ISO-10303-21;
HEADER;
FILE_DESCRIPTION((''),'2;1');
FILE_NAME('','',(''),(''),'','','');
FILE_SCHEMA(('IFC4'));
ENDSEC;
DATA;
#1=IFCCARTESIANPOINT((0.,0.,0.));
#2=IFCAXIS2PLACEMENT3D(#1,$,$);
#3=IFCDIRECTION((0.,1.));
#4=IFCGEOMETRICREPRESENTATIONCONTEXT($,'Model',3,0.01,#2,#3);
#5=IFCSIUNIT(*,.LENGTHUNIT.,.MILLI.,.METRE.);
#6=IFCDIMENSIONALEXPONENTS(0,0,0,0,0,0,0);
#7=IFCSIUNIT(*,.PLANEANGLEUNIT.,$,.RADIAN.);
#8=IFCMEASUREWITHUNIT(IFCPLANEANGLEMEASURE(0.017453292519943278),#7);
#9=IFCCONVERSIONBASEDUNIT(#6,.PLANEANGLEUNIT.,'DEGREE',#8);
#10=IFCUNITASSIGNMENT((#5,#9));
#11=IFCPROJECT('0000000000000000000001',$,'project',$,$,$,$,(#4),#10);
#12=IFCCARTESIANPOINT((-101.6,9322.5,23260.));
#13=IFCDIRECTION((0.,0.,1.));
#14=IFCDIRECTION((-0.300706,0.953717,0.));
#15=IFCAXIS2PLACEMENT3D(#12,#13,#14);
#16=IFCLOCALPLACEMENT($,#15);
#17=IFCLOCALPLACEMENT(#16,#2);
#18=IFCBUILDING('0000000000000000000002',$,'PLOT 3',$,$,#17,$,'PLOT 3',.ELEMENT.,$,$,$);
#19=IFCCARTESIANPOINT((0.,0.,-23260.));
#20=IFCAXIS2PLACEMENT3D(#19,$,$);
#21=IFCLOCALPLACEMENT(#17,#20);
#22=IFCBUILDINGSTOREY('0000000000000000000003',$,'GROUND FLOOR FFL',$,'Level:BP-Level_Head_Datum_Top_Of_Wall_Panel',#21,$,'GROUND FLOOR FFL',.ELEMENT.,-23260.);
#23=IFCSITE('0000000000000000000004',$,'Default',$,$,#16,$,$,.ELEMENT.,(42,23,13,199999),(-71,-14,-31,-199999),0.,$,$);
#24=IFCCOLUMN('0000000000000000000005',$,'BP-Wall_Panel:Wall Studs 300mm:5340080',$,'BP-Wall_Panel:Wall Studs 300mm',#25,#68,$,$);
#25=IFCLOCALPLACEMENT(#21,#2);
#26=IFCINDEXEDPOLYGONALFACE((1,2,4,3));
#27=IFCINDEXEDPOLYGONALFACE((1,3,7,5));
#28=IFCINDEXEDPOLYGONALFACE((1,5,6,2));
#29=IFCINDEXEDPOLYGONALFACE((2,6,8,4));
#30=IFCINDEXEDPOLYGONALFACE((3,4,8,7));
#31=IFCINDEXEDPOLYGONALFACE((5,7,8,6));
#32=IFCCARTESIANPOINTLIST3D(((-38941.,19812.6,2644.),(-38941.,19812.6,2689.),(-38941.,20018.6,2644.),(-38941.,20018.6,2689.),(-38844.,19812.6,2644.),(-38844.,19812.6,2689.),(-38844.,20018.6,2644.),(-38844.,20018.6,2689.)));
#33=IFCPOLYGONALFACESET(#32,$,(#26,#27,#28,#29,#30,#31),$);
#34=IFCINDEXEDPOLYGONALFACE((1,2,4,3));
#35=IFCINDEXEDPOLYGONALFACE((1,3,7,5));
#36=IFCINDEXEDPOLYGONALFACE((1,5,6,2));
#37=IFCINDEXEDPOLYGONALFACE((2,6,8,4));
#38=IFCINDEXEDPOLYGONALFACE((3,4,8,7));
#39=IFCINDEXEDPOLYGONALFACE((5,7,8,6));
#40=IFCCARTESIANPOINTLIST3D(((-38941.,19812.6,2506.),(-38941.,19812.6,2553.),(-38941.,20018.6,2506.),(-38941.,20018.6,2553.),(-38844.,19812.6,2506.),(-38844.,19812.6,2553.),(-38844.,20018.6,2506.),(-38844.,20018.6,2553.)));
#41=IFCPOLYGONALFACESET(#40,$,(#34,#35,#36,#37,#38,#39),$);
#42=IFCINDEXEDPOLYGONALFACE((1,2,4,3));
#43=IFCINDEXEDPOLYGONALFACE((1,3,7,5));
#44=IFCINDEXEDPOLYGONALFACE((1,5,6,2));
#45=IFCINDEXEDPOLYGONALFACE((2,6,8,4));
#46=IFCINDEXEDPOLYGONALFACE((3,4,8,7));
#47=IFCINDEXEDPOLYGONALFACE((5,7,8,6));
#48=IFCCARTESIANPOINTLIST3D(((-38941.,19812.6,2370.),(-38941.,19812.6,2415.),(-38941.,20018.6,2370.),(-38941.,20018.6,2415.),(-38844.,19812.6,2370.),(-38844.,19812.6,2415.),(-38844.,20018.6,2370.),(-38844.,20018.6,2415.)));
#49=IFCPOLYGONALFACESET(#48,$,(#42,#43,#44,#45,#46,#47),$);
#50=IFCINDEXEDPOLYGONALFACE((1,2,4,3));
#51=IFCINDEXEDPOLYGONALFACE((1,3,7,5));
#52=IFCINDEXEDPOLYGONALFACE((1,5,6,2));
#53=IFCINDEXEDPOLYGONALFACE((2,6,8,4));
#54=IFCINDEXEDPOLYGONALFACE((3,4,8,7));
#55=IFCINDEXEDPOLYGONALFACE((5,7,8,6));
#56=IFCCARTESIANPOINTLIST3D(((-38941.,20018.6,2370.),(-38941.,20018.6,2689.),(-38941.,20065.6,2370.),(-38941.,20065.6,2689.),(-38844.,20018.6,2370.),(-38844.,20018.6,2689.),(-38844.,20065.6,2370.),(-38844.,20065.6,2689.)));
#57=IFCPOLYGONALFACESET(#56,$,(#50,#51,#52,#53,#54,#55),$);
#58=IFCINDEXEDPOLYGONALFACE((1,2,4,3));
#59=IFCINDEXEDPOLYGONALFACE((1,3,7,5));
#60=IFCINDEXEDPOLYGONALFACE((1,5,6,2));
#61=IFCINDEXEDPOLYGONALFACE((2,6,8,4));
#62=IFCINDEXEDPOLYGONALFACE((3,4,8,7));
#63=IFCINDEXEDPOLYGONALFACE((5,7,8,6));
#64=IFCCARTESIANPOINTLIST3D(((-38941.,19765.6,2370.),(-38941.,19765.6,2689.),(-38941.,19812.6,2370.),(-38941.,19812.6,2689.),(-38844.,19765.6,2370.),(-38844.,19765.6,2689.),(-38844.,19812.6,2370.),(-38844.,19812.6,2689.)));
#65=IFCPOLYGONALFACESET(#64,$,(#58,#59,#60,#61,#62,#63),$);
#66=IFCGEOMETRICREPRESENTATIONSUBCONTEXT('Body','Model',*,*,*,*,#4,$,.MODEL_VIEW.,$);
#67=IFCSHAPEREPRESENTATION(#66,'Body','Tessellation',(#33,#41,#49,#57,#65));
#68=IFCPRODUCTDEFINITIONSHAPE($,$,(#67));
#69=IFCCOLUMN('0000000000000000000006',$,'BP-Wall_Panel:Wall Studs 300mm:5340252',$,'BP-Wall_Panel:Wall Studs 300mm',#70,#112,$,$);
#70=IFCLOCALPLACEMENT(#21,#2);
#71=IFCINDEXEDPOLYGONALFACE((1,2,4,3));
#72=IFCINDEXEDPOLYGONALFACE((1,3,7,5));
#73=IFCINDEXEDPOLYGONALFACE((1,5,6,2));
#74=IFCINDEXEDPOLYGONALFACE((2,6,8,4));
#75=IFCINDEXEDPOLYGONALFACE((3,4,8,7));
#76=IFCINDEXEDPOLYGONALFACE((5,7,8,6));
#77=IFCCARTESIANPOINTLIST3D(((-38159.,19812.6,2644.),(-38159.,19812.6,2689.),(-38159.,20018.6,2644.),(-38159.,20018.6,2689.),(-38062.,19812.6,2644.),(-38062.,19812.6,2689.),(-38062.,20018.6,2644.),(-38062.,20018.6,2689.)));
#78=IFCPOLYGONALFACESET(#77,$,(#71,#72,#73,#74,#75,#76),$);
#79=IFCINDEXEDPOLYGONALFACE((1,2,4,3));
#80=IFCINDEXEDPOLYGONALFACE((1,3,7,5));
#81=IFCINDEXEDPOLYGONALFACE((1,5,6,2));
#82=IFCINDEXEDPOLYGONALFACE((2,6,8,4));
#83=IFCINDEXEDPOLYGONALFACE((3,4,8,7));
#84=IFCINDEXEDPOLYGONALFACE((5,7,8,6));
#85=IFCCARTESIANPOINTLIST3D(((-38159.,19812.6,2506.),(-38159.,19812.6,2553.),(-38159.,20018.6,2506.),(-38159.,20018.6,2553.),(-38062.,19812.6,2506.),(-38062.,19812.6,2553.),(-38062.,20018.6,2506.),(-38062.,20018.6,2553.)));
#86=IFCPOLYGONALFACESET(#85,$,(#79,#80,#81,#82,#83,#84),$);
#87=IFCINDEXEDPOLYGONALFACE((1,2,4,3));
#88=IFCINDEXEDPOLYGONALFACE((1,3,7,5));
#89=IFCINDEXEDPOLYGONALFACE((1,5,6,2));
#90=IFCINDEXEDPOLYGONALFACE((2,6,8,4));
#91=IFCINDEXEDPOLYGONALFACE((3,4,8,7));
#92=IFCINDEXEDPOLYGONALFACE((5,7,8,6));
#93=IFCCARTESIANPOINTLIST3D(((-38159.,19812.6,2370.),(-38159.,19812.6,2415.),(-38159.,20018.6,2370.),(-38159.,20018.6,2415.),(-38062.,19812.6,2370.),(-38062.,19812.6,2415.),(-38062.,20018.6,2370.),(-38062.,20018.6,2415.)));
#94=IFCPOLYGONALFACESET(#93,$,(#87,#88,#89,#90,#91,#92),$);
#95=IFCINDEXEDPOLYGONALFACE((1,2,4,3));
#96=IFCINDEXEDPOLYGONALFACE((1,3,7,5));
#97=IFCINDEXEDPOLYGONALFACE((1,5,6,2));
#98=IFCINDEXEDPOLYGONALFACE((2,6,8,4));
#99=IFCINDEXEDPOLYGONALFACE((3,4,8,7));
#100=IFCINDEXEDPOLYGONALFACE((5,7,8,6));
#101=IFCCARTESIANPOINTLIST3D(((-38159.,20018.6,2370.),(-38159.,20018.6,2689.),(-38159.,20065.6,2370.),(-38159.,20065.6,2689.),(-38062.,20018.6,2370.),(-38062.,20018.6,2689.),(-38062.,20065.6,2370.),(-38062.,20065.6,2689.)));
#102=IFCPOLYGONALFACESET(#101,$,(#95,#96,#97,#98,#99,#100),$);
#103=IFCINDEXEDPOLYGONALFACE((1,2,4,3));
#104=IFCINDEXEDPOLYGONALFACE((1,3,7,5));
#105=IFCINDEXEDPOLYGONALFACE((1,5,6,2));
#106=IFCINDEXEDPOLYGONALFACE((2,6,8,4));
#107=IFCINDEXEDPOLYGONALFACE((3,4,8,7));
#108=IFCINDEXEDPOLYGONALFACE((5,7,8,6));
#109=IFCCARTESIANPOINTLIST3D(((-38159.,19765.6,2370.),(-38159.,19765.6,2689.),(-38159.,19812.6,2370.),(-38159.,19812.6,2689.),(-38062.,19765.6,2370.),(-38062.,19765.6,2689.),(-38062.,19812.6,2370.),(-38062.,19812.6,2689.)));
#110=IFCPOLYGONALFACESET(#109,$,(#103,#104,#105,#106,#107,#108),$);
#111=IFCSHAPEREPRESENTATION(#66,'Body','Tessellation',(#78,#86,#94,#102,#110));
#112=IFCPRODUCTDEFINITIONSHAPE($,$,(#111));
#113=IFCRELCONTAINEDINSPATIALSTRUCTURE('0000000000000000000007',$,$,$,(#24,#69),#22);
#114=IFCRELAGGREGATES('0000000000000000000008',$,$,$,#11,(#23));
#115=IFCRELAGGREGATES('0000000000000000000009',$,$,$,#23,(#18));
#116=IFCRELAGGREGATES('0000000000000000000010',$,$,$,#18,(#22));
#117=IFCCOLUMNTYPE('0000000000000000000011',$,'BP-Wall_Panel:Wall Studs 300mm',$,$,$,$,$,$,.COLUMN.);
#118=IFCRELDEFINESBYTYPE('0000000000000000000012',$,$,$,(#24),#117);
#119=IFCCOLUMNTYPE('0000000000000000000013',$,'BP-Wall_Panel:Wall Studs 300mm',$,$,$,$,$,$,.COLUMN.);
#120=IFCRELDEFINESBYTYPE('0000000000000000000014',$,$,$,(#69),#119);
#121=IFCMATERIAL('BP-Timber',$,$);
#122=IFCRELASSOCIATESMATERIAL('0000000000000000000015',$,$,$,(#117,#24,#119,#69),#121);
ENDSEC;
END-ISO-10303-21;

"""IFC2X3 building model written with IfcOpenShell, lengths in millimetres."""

from ifc_helpers import new_model, entity, si_unit, converted_unit, direction, frame, frame_2d, origin, place, context, subcontext, project, spatial, rectangle, extrude, source, transform, mapped, material, type_object, type_shapes, element, save


model = new_model("IFC2X3")

# Units and contexts
model_context = context("Model", 3, precision=0.01, world=origin(), true_north=direction((0.0, 1.0)))
body_context = subcontext(model_context, "Body", "Model", "MODEL_VIEW")
ifc_project = project(units=[si_unit("LENGTHUNIT", "METRE", prefix="MILLI"), converted_unit("PLANEANGLEUNIT", "DEGREE", entity("IfcPlaneAngleMeasure", 0.017453292519943278), si_unit("PLANEANGLEUNIT", "RADIAN"), dimensions=[0, 0, 0, 0, 0, 0, 0])], contexts=[model_context])

# Site, building, storey
site_placement = place(None, frame((-101.6, 9322.5, 23260.0), z_axis=(0.0, 0.0, 1.0), x_axis=(-0.300706, 0.953717, 0.0)))
site = spatial("IfcSite", under=ifc_project, at=site_placement, Name="Default", CompositionType="ELEMENT", RefLatitude=(42, 23, 13, 199999), RefLongitude=(-71, -14, -31, -199999), RefElevation=0.0)
building_placement = place(site_placement, origin())
building = spatial("IfcBuilding", under=site, at=building_placement, Name="PLOT 3", LongName="PLOT 3", CompositionType="ELEMENT")
storey_placement = place(building_placement, frame((0.0, 0.0, -23260.0)))
storey = spatial("IfcBuildingStorey", under=building, at=storey_placement, Name="GROUND FLOOR FFL", ObjectType="Level:BP-Level_Head_Datum_Top_Of_Wall_Panel", LongName="GROUND FLOOR FFL", CompositionType="ELEMENT", Elevation=-23260.0)

# Columns
ifc_material_1 = material(Name="BP-Timber")
column_type_1 = type_object("IfcColumnType", Name="BP-Wall_Panel:Wall Studs 300mm", PredefinedType="COLUMN", material=ifc_material_1)
shared_shape_1 = source(origin(), body_context, "Body", "SweptSolid", [
    extrude(rectangle(XDim=97.0, YDim=206.0, at=frame_2d((0.0, 0.0), x_axis=(1.0, 0.0))), frame((-38892.5, 19915.6, -20616.0), z_axis=(0.0, 0.0, 1.0), x_axis=(-1.0, 0.0, 0.0)), (0.0, 0.0, 1.0), 45.0),
    extrude(rectangle(XDim=97.0, YDim=206.0, at=frame_2d((0.0, 0.0), x_axis=(1.0, 0.0))), frame((-38892.5, 19915.6, -20754.0), z_axis=(0.0, 0.0, 1.0), x_axis=(-1.0, 0.0, 0.0)), (0.0, 0.0, 1.0), 47.0),
    extrude(rectangle(XDim=97.0, YDim=206.0, at=frame_2d((0.0, 0.0), x_axis=(1.0, 0.0))), frame((-38892.5, 19915.6, -20890.0), z_axis=(0.0, 0.0, 1.0), x_axis=(-1.0, 0.0, 0.0)), (0.0, 0.0, 1.0), 45.0),
    extrude(rectangle(XDim=47.0, YDim=97.0, at=frame_2d((0.0, 0.0), x_axis=(1.0, 0.0))), frame((-38892.5, 20042.1, -20890.0), z_axis=(0.0, 0.0, 1.0), x_axis=(0.0, -1.0, 0.0)), (0.0, 0.0, 1.0), 319.0),
    extrude(rectangle(XDim=47.0, YDim=97.0, at=frame_2d((0.0, 0.0), x_axis=(1.0, 0.0))), frame((-38892.5, 19789.1, -20890.0), z_axis=(0.0, 0.0, 1.0), x_axis=(0.0, -1.0, 0.0)), (0.0, 0.0, 1.0), 319.0),
])
type_shapes(column_type_1, [shared_shape_1])
column_1_placement = place(storey_placement, frame((0.0, 0.0, 23260.0)))
element("IfcColumn", 1, at=column_1_placement, inside=storey, type_object=column_type_1, material=ifc_material_1, Name="BP-Wall_Panel:Wall Studs 300mm:5340080", ObjectType="BP-Wall_Panel:Wall Studs 300mm", context=body_context, shape_type="MappedRepresentation", body=[
    mapped(shared_shape_1, transform((0.0, 0.0, 0.0), scale=1.0)),
])
column_type_2 = type_object("IfcColumnType", Name="BP-Wall_Panel:Wall Studs 300mm", PredefinedType="COLUMN", material=ifc_material_1)
shared_shape_2 = source(origin(), body_context, "Body", "SweptSolid", [
    extrude(rectangle(XDim=97.0, YDim=206.0, at=frame_2d((0.0, 0.0), x_axis=(1.0, 0.0))), frame((-38110.5, 19915.6, -20616.0), z_axis=(0.0, 0.0, 1.0), x_axis=(-1.0, 0.0, 0.0)), (0.0, 0.0, 1.0), 45.0),
    extrude(rectangle(XDim=97.0, YDim=206.0, at=frame_2d((0.0, 0.0), x_axis=(1.0, 0.0))), frame((-38110.5, 19915.6, -20754.0), z_axis=(0.0, 0.0, 1.0), x_axis=(-1.0, 0.0, 0.0)), (0.0, 0.0, 1.0), 47.0),
    extrude(rectangle(XDim=97.0, YDim=206.0, at=frame_2d((0.0, 0.0), x_axis=(1.0, 0.0))), frame((-38110.5, 19915.6, -20890.0), z_axis=(0.0, 0.0, 1.0), x_axis=(-1.0, 0.0, 0.0)), (0.0, 0.0, 1.0), 45.0),
    extrude(rectangle(XDim=47.0, YDim=97.0, at=frame_2d((0.0, 0.0), x_axis=(1.0, 0.0))), frame((-38110.5, 20042.1, -20890.0), z_axis=(0.0, 0.0, 1.0), x_axis=(0.0, -1.0, 0.0)), (0.0, 0.0, 1.0), 319.0),
    extrude(rectangle(XDim=47.0, YDim=97.0, at=frame_2d((0.0, 0.0), x_axis=(1.0, 0.0))), frame((-38110.5, 19789.1, -20890.0), z_axis=(0.0, 0.0, 1.0), x_axis=(0.0, -1.0, 0.0)), (0.0, 0.0, 1.0), 319.0),
])
type_shapes(column_type_2, [shared_shape_2])
column_2_placement = place(storey_placement, frame((0.0, 0.0, 23260.0)))
element("IfcColumn", 2, at=column_2_placement, inside=storey, type_object=column_type_2, material=ifc_material_1, Name="BP-Wall_Panel:Wall Studs 300mm:5340252", ObjectType="BP-Wall_Panel:Wall Studs 300mm", context=body_context, shape_type="MappedRepresentation", body=[
    mapped(shared_shape_2, transform((0.0, 0.0, 0.0), scale=1.0)),
])

save(model, "model.ifc")
